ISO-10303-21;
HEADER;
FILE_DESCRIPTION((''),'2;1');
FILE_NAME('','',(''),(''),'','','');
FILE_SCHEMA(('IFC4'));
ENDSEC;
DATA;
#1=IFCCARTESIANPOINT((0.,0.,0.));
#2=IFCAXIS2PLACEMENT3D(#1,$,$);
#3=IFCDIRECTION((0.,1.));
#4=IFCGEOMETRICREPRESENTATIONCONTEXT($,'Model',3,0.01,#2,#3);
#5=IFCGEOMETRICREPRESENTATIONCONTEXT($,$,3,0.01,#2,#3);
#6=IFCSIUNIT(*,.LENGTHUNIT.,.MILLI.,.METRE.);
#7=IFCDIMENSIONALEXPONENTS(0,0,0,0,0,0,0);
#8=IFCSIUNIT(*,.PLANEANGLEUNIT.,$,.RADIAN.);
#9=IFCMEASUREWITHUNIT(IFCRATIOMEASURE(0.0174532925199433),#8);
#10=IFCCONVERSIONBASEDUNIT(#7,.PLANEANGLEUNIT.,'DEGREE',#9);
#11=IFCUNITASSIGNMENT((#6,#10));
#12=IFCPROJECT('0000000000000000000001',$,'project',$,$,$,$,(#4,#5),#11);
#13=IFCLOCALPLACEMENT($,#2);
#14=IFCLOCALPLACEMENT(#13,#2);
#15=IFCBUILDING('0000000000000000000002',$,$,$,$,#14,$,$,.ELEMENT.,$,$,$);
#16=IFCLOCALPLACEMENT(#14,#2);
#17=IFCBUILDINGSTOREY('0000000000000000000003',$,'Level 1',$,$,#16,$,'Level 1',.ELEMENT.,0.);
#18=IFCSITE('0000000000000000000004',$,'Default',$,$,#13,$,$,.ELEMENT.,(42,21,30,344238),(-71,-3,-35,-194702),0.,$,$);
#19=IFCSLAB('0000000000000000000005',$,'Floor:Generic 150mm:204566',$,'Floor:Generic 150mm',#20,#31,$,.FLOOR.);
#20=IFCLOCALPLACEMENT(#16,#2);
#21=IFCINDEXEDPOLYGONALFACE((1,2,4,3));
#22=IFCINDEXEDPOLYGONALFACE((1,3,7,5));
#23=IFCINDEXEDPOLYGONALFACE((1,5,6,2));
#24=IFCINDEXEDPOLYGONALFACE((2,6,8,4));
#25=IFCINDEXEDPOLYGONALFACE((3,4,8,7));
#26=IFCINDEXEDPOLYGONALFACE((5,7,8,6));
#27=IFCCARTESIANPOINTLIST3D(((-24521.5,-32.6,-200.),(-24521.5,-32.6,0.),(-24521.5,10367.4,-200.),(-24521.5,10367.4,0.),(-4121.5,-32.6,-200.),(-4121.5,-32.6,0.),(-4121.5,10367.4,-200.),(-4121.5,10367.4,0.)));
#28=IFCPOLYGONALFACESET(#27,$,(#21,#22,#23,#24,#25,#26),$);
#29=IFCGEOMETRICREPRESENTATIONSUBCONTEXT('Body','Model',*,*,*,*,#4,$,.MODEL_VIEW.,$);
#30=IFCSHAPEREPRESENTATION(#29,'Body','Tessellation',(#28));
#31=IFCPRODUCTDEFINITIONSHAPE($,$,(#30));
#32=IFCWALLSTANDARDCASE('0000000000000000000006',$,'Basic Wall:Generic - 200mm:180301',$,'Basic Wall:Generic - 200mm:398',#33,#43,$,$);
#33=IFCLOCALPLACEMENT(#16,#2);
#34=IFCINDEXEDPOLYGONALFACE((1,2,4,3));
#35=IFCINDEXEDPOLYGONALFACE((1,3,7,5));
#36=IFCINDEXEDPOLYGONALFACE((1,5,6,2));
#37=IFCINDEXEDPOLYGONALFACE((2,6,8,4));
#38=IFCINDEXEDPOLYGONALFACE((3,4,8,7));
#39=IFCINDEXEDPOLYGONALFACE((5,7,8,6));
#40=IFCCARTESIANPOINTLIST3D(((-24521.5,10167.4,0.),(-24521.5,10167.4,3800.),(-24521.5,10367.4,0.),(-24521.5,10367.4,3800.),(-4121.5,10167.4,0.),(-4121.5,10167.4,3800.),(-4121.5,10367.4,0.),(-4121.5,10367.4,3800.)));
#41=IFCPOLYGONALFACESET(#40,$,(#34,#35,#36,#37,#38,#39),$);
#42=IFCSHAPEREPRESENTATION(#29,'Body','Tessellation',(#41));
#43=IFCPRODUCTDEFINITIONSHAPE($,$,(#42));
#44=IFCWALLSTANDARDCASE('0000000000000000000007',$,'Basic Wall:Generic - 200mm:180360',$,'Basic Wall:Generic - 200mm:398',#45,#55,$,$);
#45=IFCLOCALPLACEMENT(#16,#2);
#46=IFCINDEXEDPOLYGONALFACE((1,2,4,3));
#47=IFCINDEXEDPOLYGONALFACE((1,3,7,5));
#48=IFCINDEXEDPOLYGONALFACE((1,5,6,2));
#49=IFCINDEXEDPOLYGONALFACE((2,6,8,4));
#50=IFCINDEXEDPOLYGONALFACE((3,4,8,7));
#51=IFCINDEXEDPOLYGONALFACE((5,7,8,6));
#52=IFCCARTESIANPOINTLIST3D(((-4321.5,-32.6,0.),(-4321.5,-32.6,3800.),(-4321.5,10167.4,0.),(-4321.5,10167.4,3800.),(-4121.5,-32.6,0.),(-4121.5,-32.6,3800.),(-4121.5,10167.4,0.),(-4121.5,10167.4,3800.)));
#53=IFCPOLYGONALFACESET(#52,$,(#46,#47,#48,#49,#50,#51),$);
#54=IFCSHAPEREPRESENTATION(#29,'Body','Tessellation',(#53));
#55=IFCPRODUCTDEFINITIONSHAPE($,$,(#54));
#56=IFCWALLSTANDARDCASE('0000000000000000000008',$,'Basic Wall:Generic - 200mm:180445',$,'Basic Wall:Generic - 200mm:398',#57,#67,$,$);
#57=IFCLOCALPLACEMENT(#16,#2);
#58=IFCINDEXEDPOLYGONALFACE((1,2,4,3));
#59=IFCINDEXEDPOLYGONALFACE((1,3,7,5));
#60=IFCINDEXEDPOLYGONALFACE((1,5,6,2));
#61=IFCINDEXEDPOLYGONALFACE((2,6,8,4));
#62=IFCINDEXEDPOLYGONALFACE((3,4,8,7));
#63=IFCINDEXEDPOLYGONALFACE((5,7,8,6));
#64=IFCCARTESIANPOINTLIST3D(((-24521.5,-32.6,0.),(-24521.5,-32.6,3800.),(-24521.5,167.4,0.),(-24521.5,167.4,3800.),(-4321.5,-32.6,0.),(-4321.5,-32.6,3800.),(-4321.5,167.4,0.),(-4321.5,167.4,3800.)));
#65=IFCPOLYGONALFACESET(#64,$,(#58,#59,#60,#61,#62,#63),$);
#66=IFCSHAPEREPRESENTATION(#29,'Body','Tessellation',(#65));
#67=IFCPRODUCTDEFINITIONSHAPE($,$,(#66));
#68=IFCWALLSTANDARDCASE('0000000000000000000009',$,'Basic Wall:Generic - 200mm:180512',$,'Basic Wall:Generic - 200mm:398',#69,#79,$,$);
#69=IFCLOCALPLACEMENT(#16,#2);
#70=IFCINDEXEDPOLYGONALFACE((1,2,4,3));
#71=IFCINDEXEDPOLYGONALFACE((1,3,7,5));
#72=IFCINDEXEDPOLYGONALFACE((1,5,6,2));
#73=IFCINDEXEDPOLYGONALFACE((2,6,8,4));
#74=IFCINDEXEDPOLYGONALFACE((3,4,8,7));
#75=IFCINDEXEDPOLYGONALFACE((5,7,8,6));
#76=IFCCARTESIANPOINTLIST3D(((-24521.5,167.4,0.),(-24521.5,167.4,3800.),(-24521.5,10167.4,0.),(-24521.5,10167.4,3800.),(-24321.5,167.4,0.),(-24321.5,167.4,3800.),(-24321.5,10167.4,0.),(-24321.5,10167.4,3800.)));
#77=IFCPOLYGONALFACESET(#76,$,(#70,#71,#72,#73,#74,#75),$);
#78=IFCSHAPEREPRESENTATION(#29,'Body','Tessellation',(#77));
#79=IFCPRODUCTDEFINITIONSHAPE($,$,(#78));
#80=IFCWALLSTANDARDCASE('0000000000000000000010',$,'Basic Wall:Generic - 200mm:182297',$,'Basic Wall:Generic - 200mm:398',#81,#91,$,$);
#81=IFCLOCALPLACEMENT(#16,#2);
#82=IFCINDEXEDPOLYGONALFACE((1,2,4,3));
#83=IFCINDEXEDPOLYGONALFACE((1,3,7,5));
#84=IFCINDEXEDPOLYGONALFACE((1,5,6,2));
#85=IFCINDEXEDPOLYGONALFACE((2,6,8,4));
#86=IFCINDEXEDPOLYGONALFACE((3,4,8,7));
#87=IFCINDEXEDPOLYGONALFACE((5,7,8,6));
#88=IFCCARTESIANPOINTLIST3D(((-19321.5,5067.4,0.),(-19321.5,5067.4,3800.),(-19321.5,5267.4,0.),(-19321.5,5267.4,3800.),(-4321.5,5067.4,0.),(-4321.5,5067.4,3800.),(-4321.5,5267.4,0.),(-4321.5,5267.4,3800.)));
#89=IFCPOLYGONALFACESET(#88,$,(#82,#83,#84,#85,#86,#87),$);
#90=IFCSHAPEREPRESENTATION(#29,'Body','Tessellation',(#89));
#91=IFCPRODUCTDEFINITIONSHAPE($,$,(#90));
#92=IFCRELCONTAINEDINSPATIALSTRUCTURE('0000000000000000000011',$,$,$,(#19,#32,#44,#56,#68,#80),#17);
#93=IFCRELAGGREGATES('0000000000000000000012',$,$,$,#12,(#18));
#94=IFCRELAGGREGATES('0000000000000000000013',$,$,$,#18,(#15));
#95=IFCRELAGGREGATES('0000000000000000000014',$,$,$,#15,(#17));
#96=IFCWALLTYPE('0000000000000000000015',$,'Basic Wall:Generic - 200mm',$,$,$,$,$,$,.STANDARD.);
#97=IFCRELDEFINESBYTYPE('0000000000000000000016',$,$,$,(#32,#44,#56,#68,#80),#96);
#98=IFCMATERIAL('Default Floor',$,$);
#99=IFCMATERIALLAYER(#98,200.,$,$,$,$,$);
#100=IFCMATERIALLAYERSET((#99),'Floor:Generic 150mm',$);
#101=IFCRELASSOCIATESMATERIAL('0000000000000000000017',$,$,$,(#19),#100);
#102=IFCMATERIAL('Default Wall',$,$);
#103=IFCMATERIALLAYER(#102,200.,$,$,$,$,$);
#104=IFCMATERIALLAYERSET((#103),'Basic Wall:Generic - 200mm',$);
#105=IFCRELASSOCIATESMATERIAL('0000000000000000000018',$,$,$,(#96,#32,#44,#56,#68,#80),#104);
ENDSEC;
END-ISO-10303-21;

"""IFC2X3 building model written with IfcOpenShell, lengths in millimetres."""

from ifc_helpers import new_model, entity, si_unit, converted_unit, direction, frame, frame_2d, origin, place, context, subcontext, project, spatial, rectangle, extrude, material, layer, layer_set, layer_usage, type_object, element, save


model = new_model("IFC2X3")

# Units and contexts
model_context = context("Model", 3, precision=0.01, world=origin(), true_north=direction((0.0, 1.0)))
context_of_model = context(None, 3, precision=0.01, world=origin(), true_north=direction((0.0, 1.0)))
body_context = subcontext(model_context, "Body", "Model", "MODEL_VIEW")
ifc_project = project(units=[si_unit("LENGTHUNIT", "METRE", prefix="MILLI"), converted_unit("PLANEANGLEUNIT", "DEGREE", entity("IfcRatioMeasure", 0.0174532925199433), si_unit("PLANEANGLEUNIT", "RADIAN"), dimensions=[0, 0, 0, 0, 0, 0, 0])], contexts=[model_context, context_of_model])

# Site, building, storey
site_placement = place(None, origin())
site = spatial("IfcSite", under=ifc_project, at=site_placement, Name="Default", CompositionType="ELEMENT", RefLatitude=(42, 21, 30, 344238), RefLongitude=(-71, -3, -35, -194702), RefElevation=0.0)
building_placement = place(site_placement, origin())
building = spatial("IfcBuilding", under=site, at=building_placement, CompositionType="ELEMENT")
storey_placement = place(building_placement, origin())
storey = spatial("IfcBuildingStorey", under=building, at=storey_placement, Name="Level 1", LongName="Level 1", CompositionType="ELEMENT", Elevation=0.0)

# Slab
ifc_material_1 = material(Name="Default Floor")
ifc_layer_1 = layer(ifc_material_1, 200.0)
ifc_layer_set_1 = layer_set([ifc_layer_1], Name="Floor:Generic 150mm")
ifc_layer_usage_1 = layer_usage(ifc_layer_set_1, "AXIS3", "POSITIVE", 0.0)
slab_placement = place(storey_placement, origin())
element("IfcSlab", 1, at=slab_placement, inside=storey, material=ifc_layer_usage_1, Name="Floor:Generic 150mm:204566", ObjectType="Floor:Generic 150mm", PredefinedType="FLOOR", context=body_context, shape_type="SweptSolid", body=[
    extrude(rectangle(XDim=10400.0, YDim=20400.0, at=frame_2d((0.0, 0.0), x_axis=(1.0, 0.0))), frame((-14321.5, 5167.4, 0.0), z_axis=(0.0, 0.0, -1.0), x_axis=(0.0, 1.0, 0.0)), (0.0, 0.0, 1.0), 200.0),
])

# Walls
ifc_material_2 = material(Name="Default Wall")
ifc_layer_2 = layer(ifc_material_2, 200.0)
ifc_layer_set_2 = layer_set([ifc_layer_2], Name="Basic Wall:Generic - 200mm")
ifc_layer_usage_2 = layer_usage(ifc_layer_set_2, "AXIS2", "NEGATIVE", 100.0)
wall_type = type_object("IfcWallType", Name="Basic Wall:Generic - 200mm", PredefinedType="STANDARD", material=ifc_layer_set_2)
wall_1_placement = place(storey_placement, frame((-24521.5, 10267.4, 0.0)))
element("IfcWallStandardCase", 2, at=wall_1_placement, inside=storey, type_object=wall_type, material=ifc_layer_usage_2, Name="Basic Wall:Generic - 200mm:180301", ObjectType="Basic Wall:Generic - 200mm:398", context=body_context, shape_type="SweptSolid", body=[
    extrude(rectangle(XDim=20400.0, YDim=200.0, at=frame_2d((10200.0, 0.0), x_axis=(-1.0, 0.0))), origin(), (0.0, 0.0, 1.0), 3800.0),
])
ifc_layer_usage_3 = layer_usage(ifc_layer_set_2, "AXIS2", "NEGATIVE", 100.0)
wall_2_placement = place(storey_placement, frame((-4221.5, 10167.4, 0.0), z_axis=(0.0, 0.0, 1.0), x_axis=(0.0, -1.0, 0.0)))
element("IfcWallStandardCase", 3, at=wall_2_placement, inside=storey, type_object=wall_type, material=ifc_layer_usage_3, Name="Basic Wall:Generic - 200mm:180360", ObjectType="Basic Wall:Generic - 200mm:398", context=body_context, shape_type="SweptSolid", body=[
    extrude(rectangle(XDim=10200.0, YDim=200.0, at=frame_2d((5100.0, 0.0), x_axis=(-1.0, 0.0))), origin(), (0.0, 0.0, 1.0), 3800.0),
])
ifc_layer_usage_4 = layer_usage(ifc_layer_set_2, "AXIS2", "NEGATIVE", 100.0)
wall_3_placement = place(storey_placement, frame((-4321.5, 67.4, 0.0), z_axis=(0.0, 0.0, 1.0), x_axis=(-1.0, 0.0, 0.0)))
element("IfcWallStandardCase", 4, at=wall_3_placement, inside=storey, type_object=wall_type, material=ifc_layer_usage_4, Name="Basic Wall:Generic - 200mm:180445", ObjectType="Basic Wall:Generic - 200mm:398", context=body_context, shape_type="SweptSolid", body=[
    extrude(rectangle(XDim=20200.0, YDim=200.0, at=frame_2d((10100.0, 0.0), x_axis=(-1.0, 0.0))), origin(), (0.0, 0.0, 1.0), 3800.0),
])
ifc_layer_usage_5 = layer_usage(ifc_layer_set_2, "AXIS2", "NEGATIVE", 100.0)
wall_4_placement = place(storey_placement, frame((-24421.5, 167.4, 0.0), z_axis=(0.0, 0.0, 1.0), x_axis=(0.0, 1.0, 0.0)))
element("IfcWallStandardCase", 5, at=wall_4_placement, inside=storey, type_object=wall_type, material=ifc_layer_usage_5, Name="Basic Wall:Generic - 200mm:180512", ObjectType="Basic Wall:Generic - 200mm:398", context=body_context, shape_type="SweptSolid", body=[
    extrude(rectangle(XDim=10000.0, YDim=200.0, at=frame_2d((5000.0, 0.0), x_axis=(-1.0, 0.0))), origin(), (0.0, 0.0, 1.0), 3800.0),
])
ifc_layer_usage_6 = layer_usage(ifc_layer_set_2, "AXIS2", "NEGATIVE", 100.0)
wall_5_placement = place(storey_placement, frame((-4321.5, 5167.4, 0.0), z_axis=(0.0, 0.0, 1.0), x_axis=(-1.0, 0.0, 0.0)))
element("IfcWallStandardCase", 6, at=wall_5_placement, inside=storey, type_object=wall_type, material=ifc_layer_usage_6, Name="Basic Wall:Generic - 200mm:182297", ObjectType="Basic Wall:Generic - 200mm:398", context=body_context, shape_type="SweptSolid", body=[
    extrude(rectangle(XDim=15000.0, YDim=200.0, at=frame_2d((7500.0, 0.0), x_axis=(-1.0, 0.0))), origin(), (0.0, 0.0, 1.0), 3800.0),
])

save(model, "model.ifc")
